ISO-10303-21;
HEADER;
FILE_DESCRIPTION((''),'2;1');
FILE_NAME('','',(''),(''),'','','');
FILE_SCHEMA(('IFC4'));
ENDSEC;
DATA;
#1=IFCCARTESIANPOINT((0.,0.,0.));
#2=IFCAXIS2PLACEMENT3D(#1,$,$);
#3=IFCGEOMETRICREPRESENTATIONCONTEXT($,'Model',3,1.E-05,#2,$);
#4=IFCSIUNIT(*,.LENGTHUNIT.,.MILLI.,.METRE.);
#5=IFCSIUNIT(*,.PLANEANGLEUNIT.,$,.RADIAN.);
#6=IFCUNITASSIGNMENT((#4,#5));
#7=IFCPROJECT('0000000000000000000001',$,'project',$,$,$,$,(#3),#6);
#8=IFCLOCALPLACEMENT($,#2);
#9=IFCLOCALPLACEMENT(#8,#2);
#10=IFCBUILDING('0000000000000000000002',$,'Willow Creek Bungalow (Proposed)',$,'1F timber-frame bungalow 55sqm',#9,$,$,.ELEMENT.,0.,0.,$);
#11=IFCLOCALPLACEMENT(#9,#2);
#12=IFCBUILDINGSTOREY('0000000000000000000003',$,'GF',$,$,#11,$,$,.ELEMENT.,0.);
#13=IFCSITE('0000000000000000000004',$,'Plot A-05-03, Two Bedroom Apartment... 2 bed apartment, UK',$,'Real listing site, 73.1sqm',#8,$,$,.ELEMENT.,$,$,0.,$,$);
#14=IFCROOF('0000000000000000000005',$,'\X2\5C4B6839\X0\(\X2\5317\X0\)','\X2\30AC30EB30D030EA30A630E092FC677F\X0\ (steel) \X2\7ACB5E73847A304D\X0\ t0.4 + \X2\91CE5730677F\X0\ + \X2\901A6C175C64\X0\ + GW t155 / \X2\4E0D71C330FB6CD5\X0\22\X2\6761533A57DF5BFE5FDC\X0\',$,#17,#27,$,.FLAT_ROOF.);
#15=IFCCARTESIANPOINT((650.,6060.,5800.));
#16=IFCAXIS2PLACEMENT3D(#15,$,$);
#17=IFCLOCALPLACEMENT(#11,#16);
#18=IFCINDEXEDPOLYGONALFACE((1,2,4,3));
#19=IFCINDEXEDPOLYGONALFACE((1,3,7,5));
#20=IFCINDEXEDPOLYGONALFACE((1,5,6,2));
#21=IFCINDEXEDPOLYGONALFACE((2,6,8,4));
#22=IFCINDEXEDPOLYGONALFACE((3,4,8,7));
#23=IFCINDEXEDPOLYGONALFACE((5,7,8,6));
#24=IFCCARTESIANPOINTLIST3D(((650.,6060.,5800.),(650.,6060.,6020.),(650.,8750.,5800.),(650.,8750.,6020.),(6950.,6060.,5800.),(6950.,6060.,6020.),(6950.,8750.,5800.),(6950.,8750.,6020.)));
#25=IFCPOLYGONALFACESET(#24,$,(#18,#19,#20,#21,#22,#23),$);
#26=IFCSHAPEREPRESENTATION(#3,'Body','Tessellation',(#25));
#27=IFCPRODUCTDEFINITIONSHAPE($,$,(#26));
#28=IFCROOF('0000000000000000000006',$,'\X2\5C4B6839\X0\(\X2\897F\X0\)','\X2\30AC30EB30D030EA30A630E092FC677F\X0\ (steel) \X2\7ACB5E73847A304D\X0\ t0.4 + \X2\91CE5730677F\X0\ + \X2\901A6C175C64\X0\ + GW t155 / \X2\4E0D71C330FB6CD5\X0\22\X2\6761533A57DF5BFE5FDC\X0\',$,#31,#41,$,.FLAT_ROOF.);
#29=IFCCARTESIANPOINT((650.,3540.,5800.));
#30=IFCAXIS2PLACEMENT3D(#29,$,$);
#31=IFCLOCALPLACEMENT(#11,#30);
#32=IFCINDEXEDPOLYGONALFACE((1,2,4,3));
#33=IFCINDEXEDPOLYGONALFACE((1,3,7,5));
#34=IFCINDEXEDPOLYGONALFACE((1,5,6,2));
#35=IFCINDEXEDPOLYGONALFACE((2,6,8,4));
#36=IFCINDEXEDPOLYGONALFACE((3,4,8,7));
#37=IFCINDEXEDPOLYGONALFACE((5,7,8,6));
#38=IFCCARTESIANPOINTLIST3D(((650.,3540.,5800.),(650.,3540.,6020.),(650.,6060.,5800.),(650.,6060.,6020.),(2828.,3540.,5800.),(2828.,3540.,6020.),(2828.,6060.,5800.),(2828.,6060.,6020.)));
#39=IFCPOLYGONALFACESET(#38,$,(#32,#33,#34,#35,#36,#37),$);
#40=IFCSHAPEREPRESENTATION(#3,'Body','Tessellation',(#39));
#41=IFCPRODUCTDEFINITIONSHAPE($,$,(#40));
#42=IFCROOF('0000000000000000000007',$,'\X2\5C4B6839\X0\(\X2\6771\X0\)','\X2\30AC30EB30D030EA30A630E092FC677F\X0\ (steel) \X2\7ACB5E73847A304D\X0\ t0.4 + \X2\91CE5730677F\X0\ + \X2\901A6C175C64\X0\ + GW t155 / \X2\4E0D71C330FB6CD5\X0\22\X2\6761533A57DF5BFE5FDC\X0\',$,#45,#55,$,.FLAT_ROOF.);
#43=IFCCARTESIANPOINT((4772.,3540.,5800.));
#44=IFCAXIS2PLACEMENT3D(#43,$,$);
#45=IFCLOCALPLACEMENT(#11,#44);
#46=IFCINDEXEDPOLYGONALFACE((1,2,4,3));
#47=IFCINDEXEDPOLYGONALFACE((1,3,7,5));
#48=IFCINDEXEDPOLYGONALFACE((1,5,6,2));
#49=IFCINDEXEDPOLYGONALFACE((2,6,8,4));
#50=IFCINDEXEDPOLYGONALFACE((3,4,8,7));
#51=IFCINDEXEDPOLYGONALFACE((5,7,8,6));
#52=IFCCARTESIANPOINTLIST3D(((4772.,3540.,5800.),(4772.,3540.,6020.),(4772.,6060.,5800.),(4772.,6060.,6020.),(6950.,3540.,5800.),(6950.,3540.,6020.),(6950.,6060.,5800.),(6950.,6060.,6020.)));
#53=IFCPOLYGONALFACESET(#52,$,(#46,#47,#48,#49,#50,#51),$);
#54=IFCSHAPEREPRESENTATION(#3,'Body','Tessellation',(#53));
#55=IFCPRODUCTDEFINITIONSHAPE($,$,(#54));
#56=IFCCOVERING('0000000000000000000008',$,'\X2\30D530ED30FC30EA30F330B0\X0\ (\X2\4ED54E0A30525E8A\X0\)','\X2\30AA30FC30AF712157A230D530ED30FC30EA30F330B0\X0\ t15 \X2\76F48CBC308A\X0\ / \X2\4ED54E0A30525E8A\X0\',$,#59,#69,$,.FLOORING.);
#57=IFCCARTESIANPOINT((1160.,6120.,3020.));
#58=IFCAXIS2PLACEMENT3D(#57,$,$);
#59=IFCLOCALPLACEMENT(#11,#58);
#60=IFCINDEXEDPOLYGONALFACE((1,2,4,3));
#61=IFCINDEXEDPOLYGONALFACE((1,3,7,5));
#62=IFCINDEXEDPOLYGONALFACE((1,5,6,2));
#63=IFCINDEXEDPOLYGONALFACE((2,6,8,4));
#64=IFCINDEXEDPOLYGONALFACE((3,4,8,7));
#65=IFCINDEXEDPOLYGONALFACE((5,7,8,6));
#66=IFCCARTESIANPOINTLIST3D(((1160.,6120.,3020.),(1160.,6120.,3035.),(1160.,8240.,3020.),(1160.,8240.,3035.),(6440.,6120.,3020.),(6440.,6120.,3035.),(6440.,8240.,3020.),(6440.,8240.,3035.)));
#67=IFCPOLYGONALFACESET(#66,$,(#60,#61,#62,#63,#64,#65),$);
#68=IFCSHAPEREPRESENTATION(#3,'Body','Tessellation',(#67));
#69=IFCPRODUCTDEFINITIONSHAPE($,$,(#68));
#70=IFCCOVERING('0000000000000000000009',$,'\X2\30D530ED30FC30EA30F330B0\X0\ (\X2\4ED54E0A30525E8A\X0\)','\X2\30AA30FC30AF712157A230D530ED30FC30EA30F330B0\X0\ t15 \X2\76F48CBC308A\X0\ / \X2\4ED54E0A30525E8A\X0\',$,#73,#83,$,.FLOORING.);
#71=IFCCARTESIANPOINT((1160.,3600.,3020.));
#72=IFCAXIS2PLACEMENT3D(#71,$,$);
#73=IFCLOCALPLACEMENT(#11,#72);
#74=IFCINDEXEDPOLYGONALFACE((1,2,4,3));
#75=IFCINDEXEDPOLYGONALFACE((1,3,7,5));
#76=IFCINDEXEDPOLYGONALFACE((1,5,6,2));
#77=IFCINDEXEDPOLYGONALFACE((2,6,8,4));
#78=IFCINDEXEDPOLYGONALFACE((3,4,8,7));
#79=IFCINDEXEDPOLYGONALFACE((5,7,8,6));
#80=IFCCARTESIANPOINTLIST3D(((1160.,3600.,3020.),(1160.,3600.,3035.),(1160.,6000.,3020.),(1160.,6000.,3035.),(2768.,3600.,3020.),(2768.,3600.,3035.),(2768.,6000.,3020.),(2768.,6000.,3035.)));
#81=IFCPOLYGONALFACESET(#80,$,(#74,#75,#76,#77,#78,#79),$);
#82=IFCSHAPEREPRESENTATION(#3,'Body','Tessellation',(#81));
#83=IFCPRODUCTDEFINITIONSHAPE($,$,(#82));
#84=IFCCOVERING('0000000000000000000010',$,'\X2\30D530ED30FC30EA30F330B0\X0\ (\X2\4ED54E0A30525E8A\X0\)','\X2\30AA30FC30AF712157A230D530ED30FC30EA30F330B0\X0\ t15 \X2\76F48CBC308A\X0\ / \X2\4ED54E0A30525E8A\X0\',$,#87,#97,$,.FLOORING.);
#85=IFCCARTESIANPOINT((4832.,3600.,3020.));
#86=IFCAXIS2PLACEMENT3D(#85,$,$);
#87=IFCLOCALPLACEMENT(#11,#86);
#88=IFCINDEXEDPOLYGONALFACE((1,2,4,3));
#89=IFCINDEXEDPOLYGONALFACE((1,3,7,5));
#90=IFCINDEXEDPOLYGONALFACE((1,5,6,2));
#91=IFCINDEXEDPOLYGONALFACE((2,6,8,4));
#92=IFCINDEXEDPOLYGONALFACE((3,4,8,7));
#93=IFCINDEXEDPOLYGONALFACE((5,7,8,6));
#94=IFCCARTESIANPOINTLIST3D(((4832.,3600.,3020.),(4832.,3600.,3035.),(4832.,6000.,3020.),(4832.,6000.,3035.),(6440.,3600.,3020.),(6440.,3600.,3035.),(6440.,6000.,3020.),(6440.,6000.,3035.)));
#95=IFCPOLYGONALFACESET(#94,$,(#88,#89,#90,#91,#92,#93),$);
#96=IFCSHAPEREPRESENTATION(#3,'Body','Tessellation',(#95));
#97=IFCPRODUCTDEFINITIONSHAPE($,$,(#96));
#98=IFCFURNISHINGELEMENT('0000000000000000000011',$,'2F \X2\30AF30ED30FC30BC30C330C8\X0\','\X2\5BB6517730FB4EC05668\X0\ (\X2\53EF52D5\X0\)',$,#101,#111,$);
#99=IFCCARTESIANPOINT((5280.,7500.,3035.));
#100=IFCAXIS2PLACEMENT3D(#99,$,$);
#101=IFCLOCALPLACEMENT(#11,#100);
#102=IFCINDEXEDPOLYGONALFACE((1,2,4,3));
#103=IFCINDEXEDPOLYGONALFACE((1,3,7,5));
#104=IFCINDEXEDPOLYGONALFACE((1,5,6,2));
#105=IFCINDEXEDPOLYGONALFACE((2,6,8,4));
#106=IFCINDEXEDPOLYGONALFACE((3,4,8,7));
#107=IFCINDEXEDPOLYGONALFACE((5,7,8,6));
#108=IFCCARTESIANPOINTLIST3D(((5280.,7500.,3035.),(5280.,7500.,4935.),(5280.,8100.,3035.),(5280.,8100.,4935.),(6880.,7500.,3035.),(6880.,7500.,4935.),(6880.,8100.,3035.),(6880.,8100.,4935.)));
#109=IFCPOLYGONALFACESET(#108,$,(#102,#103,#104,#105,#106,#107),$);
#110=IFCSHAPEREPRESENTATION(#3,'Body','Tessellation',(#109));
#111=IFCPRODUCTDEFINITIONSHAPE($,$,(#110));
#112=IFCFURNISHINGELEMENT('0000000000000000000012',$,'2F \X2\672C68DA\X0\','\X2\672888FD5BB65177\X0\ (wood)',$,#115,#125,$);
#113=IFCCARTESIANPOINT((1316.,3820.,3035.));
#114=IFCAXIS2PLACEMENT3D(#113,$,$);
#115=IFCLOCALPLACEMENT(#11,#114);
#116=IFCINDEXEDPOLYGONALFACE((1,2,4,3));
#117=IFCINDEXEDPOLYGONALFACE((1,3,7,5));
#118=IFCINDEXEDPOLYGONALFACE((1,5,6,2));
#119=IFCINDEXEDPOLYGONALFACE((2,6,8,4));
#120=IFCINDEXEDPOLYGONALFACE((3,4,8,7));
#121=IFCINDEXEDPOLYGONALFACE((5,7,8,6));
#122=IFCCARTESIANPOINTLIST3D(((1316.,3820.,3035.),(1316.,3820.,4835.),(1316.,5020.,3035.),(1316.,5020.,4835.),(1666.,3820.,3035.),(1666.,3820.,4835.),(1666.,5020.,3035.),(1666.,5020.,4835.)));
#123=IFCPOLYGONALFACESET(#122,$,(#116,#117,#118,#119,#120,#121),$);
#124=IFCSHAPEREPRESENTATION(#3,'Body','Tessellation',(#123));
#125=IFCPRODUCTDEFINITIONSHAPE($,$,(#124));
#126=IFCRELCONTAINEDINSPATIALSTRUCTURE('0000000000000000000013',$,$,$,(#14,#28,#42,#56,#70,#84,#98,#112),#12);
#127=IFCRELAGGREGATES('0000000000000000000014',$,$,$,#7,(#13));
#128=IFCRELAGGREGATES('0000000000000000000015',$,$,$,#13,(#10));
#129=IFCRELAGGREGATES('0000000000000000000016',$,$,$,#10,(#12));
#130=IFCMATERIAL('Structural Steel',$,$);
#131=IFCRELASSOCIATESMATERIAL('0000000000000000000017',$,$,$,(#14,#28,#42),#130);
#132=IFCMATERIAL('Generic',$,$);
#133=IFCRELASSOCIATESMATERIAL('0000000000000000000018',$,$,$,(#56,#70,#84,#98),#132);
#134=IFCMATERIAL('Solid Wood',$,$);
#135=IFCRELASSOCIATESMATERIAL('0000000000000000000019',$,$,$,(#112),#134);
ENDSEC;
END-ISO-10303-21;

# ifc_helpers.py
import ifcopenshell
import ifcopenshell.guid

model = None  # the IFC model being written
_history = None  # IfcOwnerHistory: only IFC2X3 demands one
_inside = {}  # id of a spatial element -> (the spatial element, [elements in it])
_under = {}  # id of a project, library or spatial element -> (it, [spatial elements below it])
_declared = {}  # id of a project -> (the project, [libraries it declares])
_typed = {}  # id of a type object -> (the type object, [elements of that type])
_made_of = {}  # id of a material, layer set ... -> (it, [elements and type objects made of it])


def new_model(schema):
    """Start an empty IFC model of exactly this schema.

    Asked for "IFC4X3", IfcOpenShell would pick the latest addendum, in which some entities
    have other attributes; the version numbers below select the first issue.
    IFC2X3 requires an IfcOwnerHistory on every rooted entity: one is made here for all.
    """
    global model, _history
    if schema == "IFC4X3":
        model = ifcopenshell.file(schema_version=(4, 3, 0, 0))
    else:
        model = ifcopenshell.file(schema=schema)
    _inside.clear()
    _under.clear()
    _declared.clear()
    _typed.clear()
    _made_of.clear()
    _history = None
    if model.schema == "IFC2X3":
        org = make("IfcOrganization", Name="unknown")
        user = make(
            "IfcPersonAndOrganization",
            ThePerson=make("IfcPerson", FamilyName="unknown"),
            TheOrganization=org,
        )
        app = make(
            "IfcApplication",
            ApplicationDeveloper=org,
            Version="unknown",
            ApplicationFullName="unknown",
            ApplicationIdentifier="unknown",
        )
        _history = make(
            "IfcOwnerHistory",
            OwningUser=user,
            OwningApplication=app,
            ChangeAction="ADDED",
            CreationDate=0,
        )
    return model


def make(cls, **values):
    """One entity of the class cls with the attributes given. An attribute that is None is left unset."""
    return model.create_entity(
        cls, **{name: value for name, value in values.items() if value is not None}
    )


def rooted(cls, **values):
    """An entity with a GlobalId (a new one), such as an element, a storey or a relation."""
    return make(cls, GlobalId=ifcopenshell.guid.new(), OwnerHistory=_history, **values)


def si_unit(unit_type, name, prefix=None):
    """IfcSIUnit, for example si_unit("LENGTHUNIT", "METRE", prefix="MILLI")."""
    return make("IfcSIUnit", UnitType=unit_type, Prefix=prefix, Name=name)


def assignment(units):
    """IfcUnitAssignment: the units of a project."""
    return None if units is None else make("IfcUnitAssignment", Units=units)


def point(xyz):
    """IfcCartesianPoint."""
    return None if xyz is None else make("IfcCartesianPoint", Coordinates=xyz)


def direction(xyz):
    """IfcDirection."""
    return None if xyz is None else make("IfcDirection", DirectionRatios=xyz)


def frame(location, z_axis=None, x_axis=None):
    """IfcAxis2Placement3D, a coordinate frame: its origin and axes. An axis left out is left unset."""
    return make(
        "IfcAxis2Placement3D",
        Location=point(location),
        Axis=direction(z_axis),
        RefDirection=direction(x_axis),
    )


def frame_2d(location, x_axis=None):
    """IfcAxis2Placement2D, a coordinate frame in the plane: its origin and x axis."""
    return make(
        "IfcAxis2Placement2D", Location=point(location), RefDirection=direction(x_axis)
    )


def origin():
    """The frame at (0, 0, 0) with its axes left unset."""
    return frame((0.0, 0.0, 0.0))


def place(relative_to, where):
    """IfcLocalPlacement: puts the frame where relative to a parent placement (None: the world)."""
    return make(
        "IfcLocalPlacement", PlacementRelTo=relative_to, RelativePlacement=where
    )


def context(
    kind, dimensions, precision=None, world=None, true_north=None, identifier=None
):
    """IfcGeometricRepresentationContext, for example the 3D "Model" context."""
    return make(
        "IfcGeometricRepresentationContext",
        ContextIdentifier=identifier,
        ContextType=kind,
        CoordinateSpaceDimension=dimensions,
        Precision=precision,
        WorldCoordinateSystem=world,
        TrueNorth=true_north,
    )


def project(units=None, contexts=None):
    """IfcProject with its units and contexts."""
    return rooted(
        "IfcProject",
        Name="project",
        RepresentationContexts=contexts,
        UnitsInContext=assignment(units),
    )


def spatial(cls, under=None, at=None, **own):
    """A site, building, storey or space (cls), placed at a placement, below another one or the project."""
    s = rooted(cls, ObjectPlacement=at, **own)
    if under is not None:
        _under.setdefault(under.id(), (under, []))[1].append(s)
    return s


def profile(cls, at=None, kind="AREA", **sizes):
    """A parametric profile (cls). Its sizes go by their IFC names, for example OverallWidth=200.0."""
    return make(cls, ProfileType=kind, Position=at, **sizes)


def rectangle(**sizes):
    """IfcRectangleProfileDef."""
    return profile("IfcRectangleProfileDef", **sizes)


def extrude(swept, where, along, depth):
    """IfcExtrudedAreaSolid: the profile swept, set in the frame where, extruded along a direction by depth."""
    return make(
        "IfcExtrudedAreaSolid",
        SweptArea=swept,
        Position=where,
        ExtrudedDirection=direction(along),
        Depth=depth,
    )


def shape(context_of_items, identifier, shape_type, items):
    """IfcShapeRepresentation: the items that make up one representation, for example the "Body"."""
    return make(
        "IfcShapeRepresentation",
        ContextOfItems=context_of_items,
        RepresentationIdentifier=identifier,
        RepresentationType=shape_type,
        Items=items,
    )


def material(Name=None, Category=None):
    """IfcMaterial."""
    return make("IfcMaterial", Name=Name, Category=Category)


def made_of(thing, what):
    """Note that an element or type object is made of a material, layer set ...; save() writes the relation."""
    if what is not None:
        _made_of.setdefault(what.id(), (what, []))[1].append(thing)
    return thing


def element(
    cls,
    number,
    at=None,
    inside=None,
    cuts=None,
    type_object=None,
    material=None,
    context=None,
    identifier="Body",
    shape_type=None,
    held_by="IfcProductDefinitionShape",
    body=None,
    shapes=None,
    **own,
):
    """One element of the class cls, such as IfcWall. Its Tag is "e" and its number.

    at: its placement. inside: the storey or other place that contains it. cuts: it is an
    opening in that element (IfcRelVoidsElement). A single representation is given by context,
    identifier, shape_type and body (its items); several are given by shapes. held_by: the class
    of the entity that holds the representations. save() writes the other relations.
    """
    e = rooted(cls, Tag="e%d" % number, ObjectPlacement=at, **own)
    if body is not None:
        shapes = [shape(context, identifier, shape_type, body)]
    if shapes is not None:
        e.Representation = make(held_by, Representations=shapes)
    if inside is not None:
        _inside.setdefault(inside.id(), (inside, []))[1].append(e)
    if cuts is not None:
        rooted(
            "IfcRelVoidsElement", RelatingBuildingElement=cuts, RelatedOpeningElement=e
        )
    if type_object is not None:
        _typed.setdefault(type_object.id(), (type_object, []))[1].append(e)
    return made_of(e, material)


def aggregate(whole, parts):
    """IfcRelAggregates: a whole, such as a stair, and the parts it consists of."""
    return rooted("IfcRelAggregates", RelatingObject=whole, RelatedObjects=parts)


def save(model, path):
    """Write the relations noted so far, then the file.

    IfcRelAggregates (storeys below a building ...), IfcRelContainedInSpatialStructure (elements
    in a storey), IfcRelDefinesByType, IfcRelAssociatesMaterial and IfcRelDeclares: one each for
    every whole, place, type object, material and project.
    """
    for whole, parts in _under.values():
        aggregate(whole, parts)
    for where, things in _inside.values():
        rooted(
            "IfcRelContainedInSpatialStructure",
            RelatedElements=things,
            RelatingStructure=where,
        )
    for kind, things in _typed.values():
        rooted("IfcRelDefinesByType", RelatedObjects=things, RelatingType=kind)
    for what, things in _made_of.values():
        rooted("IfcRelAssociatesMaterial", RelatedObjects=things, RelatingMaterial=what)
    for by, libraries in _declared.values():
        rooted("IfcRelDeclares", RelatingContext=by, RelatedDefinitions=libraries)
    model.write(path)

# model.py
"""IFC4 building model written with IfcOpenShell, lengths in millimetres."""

from ifc_helpers import new_model, si_unit, frame, frame_2d, origin, place, context, project, spatial, rectangle, extrude, material, element, save


model = new_model("IFC4")

# Units and contexts
model_context = context("Model", 3, precision=1e-05, world=origin())
ifc_project = project(units=[si_unit("LENGTHUNIT", "METRE", prefix="MILLI"), si_unit("PLANEANGLEUNIT", "RADIAN")], contexts=[model_context])

# Site, building, storey
site_placement = place(None, origin())
site = spatial("IfcSite", under=ifc_project, at=site_placement, Name="Plot A-05-03, Two Bedroom Apartment... 2 bed apartment, UK", ObjectType="Real listing site, 73.1sqm", CompositionType="ELEMENT", RefElevation=0.0)
building_placement = place(site_placement, origin())
building = spatial("IfcBuilding", under=site, at=building_placement, Name="Willow Creek Bungalow (Proposed)", ObjectType="1F timber-frame bungalow 55sqm", CompositionType="ELEMENT", ElevationOfRefHeight=0.0, ElevationOfTerrain=0.0)
storey_placement = place(building_placement, origin())
storey = spatial("IfcBuildingStorey", under=building, at=storey_placement, Name="GF", CompositionType="ELEMENT", Elevation=0.0)

# Shared definitions
ifc_material_1 = material(Name="Solid Wood")

# Shared definitions
ifc_material_2 = material(Name="Generic")

# Roofs
ifc_material_3 = material(Name="Structural Steel")
for number, where, name in (
    (1, (650.0, 6060.0, 5800.0), "屋根(北)"),
):
    element("IfcRoof", number, at=place(storey_placement, frame(where)), inside=storey, material=ifc_material_3, Name=name, Description="ガルバリウム鋼板 (steel) 立平葺き t0.4 + 野地板 + 通気層 + GW t155 / 不燃・法22条区域対応", PredefinedType="FLAT_ROOF", context=model_context, shape_type="SweptSolid", body=[
        extrude(rectangle(XDim=6300.0, YDim=2690.0, at=frame_2d((3150.0, 1345.0))), frame((650.0, 6060.0, 5800.0)), (0.0, 0.0, 1.0), 220.0),
    ])
roof_1_placement = place(storey_placement, frame((650.0, 3540.0, 5800.0)))
element("IfcRoof", 2, at=roof_1_placement, inside=storey, material=ifc_material_3, Name="屋根(西)", Description="ガルバリウム鋼板 (steel) 立平葺き t0.4 + 野地板 + 通気層 + GW t155 / 不燃・法22条区域対応", PredefinedType="FLAT_ROOF", context=model_context, shape_type="SweptSolid", body=[
    extrude(rectangle(XDim=2178.0, YDim=2520.0, at=frame_2d((1089.0, 1260.0))), frame((650.0, 3540.0, 5800.0)), (0.0, 0.0, 1.0), 220.0),
])
roof_2_placement = place(storey_placement, frame((4772.0, 3540.0, 5800.0)))
element("IfcRoof", 3, at=roof_2_placement, inside=storey, material=ifc_material_3, Name="屋根(東)", Description="ガルバリウム鋼板 (steel) 立平葺き t0.4 + 野地板 + 通気層 + GW t155 / 不燃・法22条区域対応", PredefinedType="FLAT_ROOF", context=model_context, shape_type="SweptSolid", body=[
    extrude(rectangle(XDim=2178.0, YDim=2520.0, at=frame_2d((1089.0, 1260.0))), frame((4772.0, 3540.0, 5800.0)), (0.0, 0.0, 1.0), 220.0),
])

# Coverings
covering_1_placement = place(storey_placement, frame((1160.0, 6120.0, 3020.0)))
element("IfcCovering", 4, at=covering_1_placement, inside=storey, material=ifc_material_2, Name="フローリング (仕上げ床)", Description="オーク無垢フローリング t15 直貼り / 仕上げ床", PredefinedType="FLOORING", context=model_context, shape_type="SweptSolid", body=[
    extrude(rectangle(XDim=5280.0, YDim=2120.0, at=frame_2d((2640.0, 1060.0))), frame((1160.0, 6120.0, 3020.0)), (0.0, 0.0, 1.0), 15.0),
])
covering_2_placement = place(storey_placement, frame((1160.0, 3600.0, 3020.0)))
element("IfcCovering", 5, at=covering_2_placement, inside=storey, material=ifc_material_2, Name="フローリング (仕上げ床)", Description="オーク無垢フローリング t15 直貼り / 仕上げ床", PredefinedType="FLOORING", context=model_context, shape_type="SweptSolid", body=[
    extrude(rectangle(XDim=1608.0, YDim=2400.0, at=frame_2d((804.0, 1200.0))), frame((1160.0, 3600.0, 3020.0)), (0.0, 0.0, 1.0), 15.0),
])
covering_3_placement = place(storey_placement, frame((4832.0, 3600.0, 3020.0)))
element("IfcCovering", 6, at=covering_3_placement, inside=storey, material=ifc_material_2, Name="フローリング (仕上げ床)", Description="オーク無垢フローリング t15 直貼り / 仕上げ床", PredefinedType="FLOORING", context=model_context, shape_type="SweptSolid", body=[
    extrude(rectangle(XDim=1608.0, YDim=2400.0, at=frame_2d((804.0, 1200.0))), frame((4832.0, 3600.0, 3020.0)), (0.0, 0.0, 1.0), 15.0),
])

# Furnishing elements
furnishing_1_placement = place(storey_placement, frame((5280.0, 7500.0, 3035.0)))
element("IfcFurnishingElement", 7, at=furnishing_1_placement, inside=storey, material=ifc_material_2, Name="2F クローゼット", Description="家具・什器 (可動)", context=model_context, shape_type="SweptSolid", body=[
    extrude(rectangle(XDim=1600.0, YDim=600.0, at=frame_2d((800.0, 300.0))), frame((5280.0, 7500.0, 3035.0)), (0.0, 0.0, 1.0), 1900.0),
])
furnishing_2_placement = place(storey_placement, frame((1316.0, 3820.0, 3035.0)))
element("IfcFurnishingElement", 8, at=furnishing_2_placement, inside=storey, material=ifc_material_1, Name="2F 本棚", Description="木製家具 (wood)", context=model_context, shape_type="SweptSolid", body=[
    extrude(rectangle(XDim=350.0, YDim=1200.0, at=frame_2d((175.0, 600.0))), frame((1316.0, 3820.0, 3035.0)), (0.0, 0.0, 1.0), 1800.0),
])

save(model, "model.ifc")
